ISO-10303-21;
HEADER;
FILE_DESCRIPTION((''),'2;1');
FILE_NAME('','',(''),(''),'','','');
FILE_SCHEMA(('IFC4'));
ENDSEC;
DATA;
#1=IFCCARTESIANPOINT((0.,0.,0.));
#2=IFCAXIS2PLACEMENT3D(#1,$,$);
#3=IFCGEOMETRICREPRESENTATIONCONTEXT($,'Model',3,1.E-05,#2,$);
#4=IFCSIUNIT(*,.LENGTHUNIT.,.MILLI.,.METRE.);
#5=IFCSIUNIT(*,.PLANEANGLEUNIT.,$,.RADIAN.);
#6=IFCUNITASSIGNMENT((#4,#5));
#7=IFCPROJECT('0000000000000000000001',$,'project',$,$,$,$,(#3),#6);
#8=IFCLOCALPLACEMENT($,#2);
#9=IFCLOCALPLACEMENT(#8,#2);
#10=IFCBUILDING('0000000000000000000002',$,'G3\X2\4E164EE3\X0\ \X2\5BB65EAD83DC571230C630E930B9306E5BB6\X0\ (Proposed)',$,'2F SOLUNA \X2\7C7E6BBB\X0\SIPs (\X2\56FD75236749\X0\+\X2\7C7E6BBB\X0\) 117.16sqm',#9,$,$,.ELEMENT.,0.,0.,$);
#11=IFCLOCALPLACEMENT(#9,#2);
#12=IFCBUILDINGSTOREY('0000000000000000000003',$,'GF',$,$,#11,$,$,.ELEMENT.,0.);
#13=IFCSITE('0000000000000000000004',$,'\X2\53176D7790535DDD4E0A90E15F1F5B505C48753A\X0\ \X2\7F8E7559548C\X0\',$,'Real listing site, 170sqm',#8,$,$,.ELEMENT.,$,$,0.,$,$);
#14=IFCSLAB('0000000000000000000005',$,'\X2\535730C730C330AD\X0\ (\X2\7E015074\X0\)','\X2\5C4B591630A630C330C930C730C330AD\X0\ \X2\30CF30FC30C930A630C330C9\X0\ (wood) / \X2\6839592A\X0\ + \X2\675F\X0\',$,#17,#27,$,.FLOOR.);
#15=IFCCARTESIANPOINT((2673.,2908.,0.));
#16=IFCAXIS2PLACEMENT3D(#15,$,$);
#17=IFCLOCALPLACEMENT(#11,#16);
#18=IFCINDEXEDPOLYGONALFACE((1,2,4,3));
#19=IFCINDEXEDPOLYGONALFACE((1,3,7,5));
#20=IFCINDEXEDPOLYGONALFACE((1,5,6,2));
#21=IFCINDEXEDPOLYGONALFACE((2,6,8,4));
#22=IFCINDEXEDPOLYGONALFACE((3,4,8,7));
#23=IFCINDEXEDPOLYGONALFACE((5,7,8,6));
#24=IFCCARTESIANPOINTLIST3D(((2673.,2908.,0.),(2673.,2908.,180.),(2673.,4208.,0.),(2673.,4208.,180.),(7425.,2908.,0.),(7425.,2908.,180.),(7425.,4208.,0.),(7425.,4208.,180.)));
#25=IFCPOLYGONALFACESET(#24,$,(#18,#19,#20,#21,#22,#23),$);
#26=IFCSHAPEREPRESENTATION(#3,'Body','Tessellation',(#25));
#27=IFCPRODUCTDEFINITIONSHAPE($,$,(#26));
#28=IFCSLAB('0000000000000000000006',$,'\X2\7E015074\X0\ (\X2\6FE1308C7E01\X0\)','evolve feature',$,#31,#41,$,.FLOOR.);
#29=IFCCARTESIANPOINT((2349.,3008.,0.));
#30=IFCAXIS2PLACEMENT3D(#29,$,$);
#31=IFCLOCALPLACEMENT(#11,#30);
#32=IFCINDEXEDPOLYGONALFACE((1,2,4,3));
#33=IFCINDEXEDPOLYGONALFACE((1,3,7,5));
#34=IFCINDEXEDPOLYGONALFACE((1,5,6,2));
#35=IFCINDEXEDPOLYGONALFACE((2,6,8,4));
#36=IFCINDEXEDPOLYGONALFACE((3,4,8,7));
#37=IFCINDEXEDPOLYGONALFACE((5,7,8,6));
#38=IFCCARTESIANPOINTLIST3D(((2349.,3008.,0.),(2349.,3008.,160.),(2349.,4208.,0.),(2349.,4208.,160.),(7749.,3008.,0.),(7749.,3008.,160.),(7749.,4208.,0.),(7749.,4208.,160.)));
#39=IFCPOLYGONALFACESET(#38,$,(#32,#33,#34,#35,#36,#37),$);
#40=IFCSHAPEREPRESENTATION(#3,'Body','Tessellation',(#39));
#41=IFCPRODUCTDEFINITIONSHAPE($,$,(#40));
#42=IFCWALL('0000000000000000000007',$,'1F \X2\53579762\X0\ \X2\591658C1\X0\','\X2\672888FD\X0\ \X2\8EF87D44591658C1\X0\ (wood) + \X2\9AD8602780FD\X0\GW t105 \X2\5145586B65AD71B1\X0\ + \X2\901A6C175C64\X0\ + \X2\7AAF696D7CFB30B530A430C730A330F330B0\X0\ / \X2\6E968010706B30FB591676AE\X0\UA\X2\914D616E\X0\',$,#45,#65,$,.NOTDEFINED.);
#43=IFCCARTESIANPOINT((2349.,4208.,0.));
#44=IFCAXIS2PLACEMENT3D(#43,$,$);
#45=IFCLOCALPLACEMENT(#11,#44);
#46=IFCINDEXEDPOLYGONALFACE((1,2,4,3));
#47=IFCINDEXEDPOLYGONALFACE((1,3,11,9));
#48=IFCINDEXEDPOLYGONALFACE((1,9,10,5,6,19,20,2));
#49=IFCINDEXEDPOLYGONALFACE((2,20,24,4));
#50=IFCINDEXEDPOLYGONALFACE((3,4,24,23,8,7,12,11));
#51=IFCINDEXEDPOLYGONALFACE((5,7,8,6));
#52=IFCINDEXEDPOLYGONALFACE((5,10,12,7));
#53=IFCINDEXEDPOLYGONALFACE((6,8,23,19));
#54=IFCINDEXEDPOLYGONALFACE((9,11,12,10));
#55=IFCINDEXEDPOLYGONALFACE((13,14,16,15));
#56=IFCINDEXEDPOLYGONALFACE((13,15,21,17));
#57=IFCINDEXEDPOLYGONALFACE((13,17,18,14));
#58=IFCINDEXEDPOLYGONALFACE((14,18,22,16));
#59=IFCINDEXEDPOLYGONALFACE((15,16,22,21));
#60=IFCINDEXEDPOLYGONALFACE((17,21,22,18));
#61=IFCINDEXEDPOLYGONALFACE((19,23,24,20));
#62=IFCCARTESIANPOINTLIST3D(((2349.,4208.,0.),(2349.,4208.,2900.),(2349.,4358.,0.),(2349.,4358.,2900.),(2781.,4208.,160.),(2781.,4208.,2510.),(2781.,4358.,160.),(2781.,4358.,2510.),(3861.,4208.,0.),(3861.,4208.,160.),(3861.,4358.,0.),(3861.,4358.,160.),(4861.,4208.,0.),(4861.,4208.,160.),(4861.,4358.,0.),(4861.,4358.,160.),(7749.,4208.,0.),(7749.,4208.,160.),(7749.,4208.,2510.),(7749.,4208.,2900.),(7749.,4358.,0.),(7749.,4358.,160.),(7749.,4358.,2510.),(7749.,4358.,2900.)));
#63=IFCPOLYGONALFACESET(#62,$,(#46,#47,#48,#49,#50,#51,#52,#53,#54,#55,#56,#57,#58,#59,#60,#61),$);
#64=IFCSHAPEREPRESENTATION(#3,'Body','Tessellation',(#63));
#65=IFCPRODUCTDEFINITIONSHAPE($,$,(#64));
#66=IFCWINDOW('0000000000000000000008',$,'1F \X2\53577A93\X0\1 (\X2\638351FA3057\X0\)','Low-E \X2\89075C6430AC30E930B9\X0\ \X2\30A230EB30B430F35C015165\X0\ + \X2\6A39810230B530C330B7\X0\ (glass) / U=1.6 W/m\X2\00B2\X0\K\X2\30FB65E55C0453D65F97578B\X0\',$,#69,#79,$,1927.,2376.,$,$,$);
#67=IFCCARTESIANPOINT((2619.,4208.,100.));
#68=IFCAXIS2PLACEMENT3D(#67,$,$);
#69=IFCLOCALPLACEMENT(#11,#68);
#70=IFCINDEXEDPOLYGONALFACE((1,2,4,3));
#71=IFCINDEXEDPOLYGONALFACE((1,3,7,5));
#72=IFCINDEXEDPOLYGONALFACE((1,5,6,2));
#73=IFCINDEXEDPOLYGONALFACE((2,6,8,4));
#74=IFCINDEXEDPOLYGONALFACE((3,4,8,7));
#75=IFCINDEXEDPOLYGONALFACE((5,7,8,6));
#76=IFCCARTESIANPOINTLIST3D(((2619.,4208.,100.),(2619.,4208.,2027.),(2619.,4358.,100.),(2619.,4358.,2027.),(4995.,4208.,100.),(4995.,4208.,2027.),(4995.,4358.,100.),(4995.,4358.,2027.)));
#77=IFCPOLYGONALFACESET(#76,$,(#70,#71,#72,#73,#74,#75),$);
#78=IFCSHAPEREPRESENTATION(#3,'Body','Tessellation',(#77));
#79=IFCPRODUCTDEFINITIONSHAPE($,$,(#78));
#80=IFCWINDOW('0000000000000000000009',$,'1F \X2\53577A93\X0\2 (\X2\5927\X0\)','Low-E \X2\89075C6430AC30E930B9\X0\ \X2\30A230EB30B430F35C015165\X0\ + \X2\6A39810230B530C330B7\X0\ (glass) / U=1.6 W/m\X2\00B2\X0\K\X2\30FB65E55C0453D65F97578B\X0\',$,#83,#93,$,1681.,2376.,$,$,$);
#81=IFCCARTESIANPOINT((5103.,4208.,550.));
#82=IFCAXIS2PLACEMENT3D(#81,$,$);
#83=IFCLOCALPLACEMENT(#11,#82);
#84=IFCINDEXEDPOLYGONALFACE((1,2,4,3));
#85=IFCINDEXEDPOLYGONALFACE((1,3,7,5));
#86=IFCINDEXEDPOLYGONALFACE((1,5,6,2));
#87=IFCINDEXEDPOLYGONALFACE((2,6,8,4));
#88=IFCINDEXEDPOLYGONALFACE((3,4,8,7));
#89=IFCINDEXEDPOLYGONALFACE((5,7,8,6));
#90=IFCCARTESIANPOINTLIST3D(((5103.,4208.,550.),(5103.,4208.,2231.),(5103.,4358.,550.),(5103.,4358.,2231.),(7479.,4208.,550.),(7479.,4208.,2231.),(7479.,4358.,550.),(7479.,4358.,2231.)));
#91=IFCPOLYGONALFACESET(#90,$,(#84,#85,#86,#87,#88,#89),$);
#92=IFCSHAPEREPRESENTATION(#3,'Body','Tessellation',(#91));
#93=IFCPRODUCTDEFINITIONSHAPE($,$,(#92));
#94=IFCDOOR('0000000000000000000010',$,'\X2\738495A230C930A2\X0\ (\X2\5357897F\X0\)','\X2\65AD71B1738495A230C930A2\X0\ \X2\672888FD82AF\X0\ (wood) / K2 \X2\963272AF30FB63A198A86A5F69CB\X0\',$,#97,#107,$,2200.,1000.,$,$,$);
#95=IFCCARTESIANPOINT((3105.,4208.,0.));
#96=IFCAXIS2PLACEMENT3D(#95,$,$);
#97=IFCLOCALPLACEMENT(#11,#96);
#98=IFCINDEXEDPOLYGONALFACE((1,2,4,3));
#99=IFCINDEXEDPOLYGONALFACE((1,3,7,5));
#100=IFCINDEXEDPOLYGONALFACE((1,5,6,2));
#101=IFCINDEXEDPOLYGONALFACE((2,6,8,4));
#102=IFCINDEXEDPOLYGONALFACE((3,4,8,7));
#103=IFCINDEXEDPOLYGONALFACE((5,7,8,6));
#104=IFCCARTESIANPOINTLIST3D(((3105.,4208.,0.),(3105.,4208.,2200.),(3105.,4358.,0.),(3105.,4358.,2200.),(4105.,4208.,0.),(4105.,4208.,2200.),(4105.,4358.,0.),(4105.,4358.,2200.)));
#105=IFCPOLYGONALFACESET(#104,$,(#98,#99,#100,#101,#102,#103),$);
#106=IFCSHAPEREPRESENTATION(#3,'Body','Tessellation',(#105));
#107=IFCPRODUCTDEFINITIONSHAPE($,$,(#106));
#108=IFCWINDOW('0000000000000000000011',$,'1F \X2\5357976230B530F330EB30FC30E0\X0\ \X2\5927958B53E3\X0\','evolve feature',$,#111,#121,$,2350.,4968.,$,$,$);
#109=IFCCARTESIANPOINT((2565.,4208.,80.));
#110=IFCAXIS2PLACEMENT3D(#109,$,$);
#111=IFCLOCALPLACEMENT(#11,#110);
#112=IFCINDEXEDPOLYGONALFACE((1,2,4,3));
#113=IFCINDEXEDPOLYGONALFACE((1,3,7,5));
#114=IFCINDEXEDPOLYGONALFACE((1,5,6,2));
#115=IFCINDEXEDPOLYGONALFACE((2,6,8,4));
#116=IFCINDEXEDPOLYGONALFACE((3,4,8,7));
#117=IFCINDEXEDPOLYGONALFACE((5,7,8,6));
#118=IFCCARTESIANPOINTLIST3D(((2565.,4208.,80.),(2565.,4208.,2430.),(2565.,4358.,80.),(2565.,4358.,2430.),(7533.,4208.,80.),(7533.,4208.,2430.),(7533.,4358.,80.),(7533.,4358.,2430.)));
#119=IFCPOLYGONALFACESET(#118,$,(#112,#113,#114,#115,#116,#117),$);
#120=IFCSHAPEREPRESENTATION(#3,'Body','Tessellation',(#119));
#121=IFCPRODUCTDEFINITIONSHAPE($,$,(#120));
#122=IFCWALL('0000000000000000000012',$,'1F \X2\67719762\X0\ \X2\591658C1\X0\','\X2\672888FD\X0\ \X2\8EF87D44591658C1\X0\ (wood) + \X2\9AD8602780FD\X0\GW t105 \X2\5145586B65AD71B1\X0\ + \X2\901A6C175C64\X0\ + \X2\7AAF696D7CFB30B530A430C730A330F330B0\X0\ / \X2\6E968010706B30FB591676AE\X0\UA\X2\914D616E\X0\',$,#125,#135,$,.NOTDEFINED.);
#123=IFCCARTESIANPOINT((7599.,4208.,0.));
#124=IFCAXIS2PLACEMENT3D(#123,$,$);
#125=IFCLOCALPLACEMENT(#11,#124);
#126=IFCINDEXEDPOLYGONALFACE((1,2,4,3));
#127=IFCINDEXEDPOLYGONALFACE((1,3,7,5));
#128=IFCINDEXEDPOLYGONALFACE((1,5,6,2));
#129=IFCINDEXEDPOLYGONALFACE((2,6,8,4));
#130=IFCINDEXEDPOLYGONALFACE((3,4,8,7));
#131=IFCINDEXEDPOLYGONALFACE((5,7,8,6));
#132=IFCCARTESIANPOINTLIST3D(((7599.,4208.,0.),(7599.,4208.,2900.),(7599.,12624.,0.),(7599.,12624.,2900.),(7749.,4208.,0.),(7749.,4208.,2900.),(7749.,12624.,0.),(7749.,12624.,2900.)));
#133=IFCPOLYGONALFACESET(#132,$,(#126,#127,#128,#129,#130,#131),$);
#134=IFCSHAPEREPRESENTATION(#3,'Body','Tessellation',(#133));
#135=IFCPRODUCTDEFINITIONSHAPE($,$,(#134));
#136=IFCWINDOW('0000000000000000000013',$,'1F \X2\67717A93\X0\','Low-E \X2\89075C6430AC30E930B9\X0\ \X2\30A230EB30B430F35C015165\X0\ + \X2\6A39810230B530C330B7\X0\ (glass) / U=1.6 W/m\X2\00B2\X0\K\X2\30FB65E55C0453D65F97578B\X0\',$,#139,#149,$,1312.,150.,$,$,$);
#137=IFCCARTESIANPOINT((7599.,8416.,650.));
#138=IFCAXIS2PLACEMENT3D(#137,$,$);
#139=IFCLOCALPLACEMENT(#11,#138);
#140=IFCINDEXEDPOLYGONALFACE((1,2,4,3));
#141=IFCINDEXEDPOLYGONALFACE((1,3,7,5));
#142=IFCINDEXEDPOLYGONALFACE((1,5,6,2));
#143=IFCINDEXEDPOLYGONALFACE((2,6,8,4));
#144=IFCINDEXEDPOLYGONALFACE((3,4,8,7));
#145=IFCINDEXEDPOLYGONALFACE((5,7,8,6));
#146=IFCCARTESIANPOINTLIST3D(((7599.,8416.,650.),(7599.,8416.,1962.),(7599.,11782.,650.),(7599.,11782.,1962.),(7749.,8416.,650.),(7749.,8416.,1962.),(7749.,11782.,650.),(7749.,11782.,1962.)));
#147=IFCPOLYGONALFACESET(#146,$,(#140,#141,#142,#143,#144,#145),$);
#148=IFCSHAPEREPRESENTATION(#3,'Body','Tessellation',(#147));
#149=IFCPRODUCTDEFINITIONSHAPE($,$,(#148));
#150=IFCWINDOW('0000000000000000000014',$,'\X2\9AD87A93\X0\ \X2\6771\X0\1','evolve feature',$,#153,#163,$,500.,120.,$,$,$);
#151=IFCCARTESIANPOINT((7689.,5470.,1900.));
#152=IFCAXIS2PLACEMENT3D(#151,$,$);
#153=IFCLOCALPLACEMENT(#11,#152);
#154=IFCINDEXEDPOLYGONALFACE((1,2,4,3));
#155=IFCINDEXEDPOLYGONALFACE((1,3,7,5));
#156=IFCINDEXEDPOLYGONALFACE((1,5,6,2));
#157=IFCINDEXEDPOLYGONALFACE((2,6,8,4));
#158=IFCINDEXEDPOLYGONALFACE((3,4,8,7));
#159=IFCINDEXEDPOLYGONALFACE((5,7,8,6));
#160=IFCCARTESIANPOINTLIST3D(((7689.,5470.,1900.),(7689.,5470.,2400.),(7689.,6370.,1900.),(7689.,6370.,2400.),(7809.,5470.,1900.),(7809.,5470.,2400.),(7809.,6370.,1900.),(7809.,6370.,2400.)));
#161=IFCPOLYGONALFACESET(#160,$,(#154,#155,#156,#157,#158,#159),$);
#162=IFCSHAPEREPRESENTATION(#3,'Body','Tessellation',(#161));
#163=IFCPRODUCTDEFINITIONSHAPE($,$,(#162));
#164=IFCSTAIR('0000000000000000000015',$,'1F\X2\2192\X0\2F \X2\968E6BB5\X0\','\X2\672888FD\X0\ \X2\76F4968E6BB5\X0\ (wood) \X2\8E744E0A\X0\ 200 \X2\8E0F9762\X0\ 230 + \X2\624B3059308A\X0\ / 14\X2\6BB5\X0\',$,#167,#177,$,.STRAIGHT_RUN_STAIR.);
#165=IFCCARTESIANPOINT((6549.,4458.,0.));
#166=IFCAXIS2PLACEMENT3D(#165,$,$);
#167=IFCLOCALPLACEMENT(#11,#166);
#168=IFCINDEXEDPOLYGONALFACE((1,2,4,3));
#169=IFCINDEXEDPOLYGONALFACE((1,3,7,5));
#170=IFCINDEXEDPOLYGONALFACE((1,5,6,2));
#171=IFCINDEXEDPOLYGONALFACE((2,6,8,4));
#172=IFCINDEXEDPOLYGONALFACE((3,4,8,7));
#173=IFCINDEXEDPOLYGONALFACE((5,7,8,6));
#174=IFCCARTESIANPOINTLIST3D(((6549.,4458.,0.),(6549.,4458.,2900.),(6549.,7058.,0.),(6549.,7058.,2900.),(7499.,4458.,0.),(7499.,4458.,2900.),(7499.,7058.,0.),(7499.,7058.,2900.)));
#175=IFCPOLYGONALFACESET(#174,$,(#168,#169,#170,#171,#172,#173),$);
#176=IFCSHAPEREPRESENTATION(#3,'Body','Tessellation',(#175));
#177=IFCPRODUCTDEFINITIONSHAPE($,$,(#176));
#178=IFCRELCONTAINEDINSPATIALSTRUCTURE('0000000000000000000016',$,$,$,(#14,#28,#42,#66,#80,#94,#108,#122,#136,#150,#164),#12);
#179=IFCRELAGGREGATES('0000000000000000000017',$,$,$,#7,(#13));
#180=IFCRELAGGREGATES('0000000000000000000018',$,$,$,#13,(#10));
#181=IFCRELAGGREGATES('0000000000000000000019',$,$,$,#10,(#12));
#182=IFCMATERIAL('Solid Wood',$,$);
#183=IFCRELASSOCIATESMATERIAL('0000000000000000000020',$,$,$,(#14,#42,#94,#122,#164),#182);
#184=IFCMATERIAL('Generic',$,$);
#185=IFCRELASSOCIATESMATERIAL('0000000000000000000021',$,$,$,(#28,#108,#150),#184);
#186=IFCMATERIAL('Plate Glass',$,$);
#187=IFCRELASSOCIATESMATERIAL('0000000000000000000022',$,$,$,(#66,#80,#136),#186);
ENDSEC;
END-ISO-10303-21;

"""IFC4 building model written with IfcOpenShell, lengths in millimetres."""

from ifc_helpers import new_model, si_unit, frame, frame_2d, origin, place, context, project, spatial, rectangle, extrude, material, element, fill, save


model = new_model("IFC4")

# Units and contexts
model_context = context("Model", 3, precision=1e-05, world=origin())
ifc_project = project(units=[si_unit("LENGTHUNIT", "METRE", prefix="MILLI"), si_unit("PLANEANGLEUNIT", "RADIAN")], contexts=[model_context])

# Site, building, storey
site_placement = place(None, origin())
site = spatial("IfcSite", under=ifc_project, at=site_placement, Name="北海道川上郡弟子屈町 美留和", ObjectType="Real listing site, 170sqm", CompositionType="ELEMENT", RefElevation=0.0)
building_placement = place(site_placement, origin())
building = spatial("IfcBuilding", under=site, at=building_placement, Name="G3世代 家庭菜園テラスの家 (Proposed)", ObjectType="2F SOLUNA 籾殻SIPs (国産杉+籾殻) 117.16sqm", CompositionType="ELEMENT", ElevationOfRefHeight=0.0, ElevationOfTerrain=0.0)
storey_placement = place(building_placement, origin())
storey = spatial("IfcBuildingStorey", under=building, at=storey_placement, Name="GF", CompositionType="ELEMENT", Elevation=0.0)

# Slabs
ifc_material_1 = material(Name="Solid Wood")
slab_1_placement = place(storey_placement, frame((2673.0, 2908.0, 0.0)))
element("IfcSlab", 1, at=slab_1_placement, inside=storey, material=ifc_material_1, Name="南デッキ (縁側)", Description="屋外ウッドデッキ ハードウッド (wood) / 根太 + 束", PredefinedType="FLOOR", context=model_context, shape_type="SweptSolid", body=[
    extrude(rectangle(XDim=4752.0, YDim=1300.0, at=frame_2d((2376.0, 650.0))), frame((2673.0, 2908.0, 0.0)), (0.0, 0.0, 1.0), 180.0),
])
ifc_material_2 = material(Name="Generic")
slab_2_placement = place(storey_placement, frame((2349.0, 3008.0, 0.0)))
element("IfcSlab", 2, at=slab_2_placement, inside=storey, material=ifc_material_2, Name="縁側 (濡れ縁)", Description="evolve feature", PredefinedType="FLOOR", context=model_context, shape_type="SweptSolid", body=[
    extrude(rectangle(XDim=5400.0, YDim=1200.0, at=frame_2d((2700.0, 600.0))), frame((2349.0, 3008.0, 0.0)), (0.0, 0.0, 1.0), 160.0),
])

# Wall, openings, windows, door
wall_1_placement = place(storey_placement, frame((2349.0, 4208.0, 0.0)))
wall_1 = element("IfcWall", 3, at=wall_1_placement, inside=storey, material=ifc_material_1, Name="1F 南面 外壁", Description="木製 軸組外壁 (wood) + 高性能GW t105 充填断熱 + 通気層 + 窯業系サイディング / 準耐火・外皮UA配慮", PredefinedType="NOTDEFINED", context=model_context, shape_type="SweptSolid", body=[
    extrude(rectangle(XDim=5400.0, YDim=150.0, at=frame_2d((2700.0, 75.0))), frame((2349.0, 4208.0, 0.0)), (0.0, 0.0, 1.0), 2900.0),
])
opening_1_placement = place(storey_placement, frame((2619.0, 4208.0, 100.0)))
opening_1 = element("IfcOpeningElement", 4, at=opening_1_placement, cuts=wall_1, PredefinedType="NOTDEFINED", context=model_context, shape_type="SweptSolid", body=[
    extrude(rectangle(XDim=2376.0, YDim=150.0, at=frame_2d((1188.0, 75.0))), frame((2619.0, 4208.0, 100.0)), (0.0, 0.0, 1.0), 1927.0),
])
opening_2_placement = place(storey_placement, frame((5103.0, 4208.0, 550.0)))
opening_2 = element("IfcOpeningElement", 5, at=opening_2_placement, cuts=wall_1, PredefinedType="NOTDEFINED", context=model_context, shape_type="SweptSolid", body=[
    extrude(rectangle(XDim=2376.0, YDim=150.0, at=frame_2d((1188.0, 75.0))), frame((5103.0, 4208.0, 550.0)), (0.0, 0.0, 1.0), 1681.0),
])
opening_3_placement = place(storey_placement, frame((3105.0, 4208.0, 0.0)))
opening_3 = element("IfcOpeningElement", 6, at=opening_3_placement, cuts=wall_1, PredefinedType="NOTDEFINED", context=model_context, shape_type="SweptSolid", body=[
    extrude(rectangle(XDim=1000.0, YDim=150.0, at=frame_2d((500.0, 75.0))), frame((3105.0, 4208.0, 0.0)), (0.0, 0.0, 1.0), 2200.0),
])
opening_4_placement = place(storey_placement, frame((2565.0, 4208.0, 80.0)))
opening_4 = element("IfcOpeningElement", 7, at=opening_4_placement, cuts=wall_1, PredefinedType="NOTDEFINED", context=model_context, shape_type="SweptSolid", body=[
    extrude(rectangle(XDim=4968.0, YDim=150.0, at=frame_2d((2484.0, 75.0))), frame((2565.0, 4208.0, 80.0)), (0.0, 0.0, 1.0), 2350.0),
])
ifc_material_3 = material(Name="Plate Glass")
window_1_placement = place(storey_placement, frame((2619.0, 4208.0, 100.0)))
window_1 = element("IfcWindow", 8, at=window_1_placement, inside=storey, material=ifc_material_3, Name="1F 南窓1 (掃出し)", Description="Low-E 複層ガラス アルゴン封入 + 樹脂サッシ (glass) / U=1.6 W/m²K・日射取得型", OverallHeight=1927.0, OverallWidth=2376.0, context=model_context, shape_type="SweptSolid", body=[
    extrude(rectangle(XDim=2376.0, YDim=150.0, at=frame_2d((1188.0, 75.0))), frame((2619.0, 4208.0, 100.0)), (0.0, 0.0, 1.0), 1927.0),
])
fill(opening_1, window_1)
window_2_placement = place(storey_placement, frame((5103.0, 4208.0, 550.0)))
window_2 = element("IfcWindow", 9, at=window_2_placement, inside=storey, material=ifc_material_3, Name="1F 南窓2 (大)", Description="Low-E 複層ガラス アルゴン封入 + 樹脂サッシ (glass) / U=1.6 W/m²K・日射取得型", OverallHeight=1681.0, OverallWidth=2376.0, context=model_context, shape_type="SweptSolid", body=[
    extrude(rectangle(XDim=2376.0, YDim=150.0, at=frame_2d((1188.0, 75.0))), frame((5103.0, 4208.0, 550.0)), (0.0, 0.0, 1.0), 1681.0),
])
fill(opening_2, window_2)
door_placement = place(storey_placement, frame((3105.0, 4208.0, 0.0)))
door = element("IfcDoor", 10, at=door_placement, inside=storey, material=ifc_material_1, Name="玄関ドア (南西)", Description="断熱玄関ドア 木製芯 (wood) / K2 防犯・採風機構", OverallHeight=2200.0, OverallWidth=1000.0, context=model_context, shape_type="SweptSolid", body=[
    extrude(rectangle(XDim=1000.0, YDim=150.0, at=frame_2d((500.0, 75.0))), frame((3105.0, 4208.0, 0.0)), (0.0, 0.0, 1.0), 2200.0),
])
fill(opening_3, door)
window_3_placement = place(storey_placement, frame((2565.0, 4208.0, 80.0)))
window_3 = element("IfcWindow", 11, at=window_3_placement, inside=storey, material=ifc_material_2, Name="1F 南面サンルーム 大開口", Description="evolve feature", OverallHeight=2350.0, OverallWidth=4968.0, context=model_context, shape_type="SweptSolid", body=[
    extrude(rectangle(XDim=4968.0, YDim=150.0, at=frame_2d((2484.0, 75.0))), frame((2565.0, 4208.0, 80.0)), (0.0, 0.0, 1.0), 2350.0),
])
fill(opening_4, window_3)

# Wall, openings, windows
wall_2_placement = place(storey_placement, frame((7599.0, 4208.0, 0.0)))
wall_2 = element("IfcWall", 12, at=wall_2_placement, inside=storey, material=ifc_material_1, Name="1F 東面 外壁", Description="木製 軸組外壁 (wood) + 高性能GW t105 充填断熱 + 通気層 + 窯業系サイディング / 準耐火・外皮UA配慮", PredefinedType="NOTDEFINED", context=model_context, shape_type="SweptSolid", body=[
    extrude(rectangle(XDim=150.0, YDim=8416.0, at=frame_2d((75.0, 4208.0))), frame((7599.0, 4208.0, 0.0)), (0.0, 0.0, 1.0), 2900.0),
])
opening_5_placement = place(storey_placement, frame((7599.0, 8416.0, 650.0)))
opening_5 = element("IfcOpeningElement", 13, at=opening_5_placement, cuts=wall_2, PredefinedType="NOTDEFINED", context=model_context, shape_type="SweptSolid", body=[
    extrude(rectangle(XDim=150.0, YDim=3366.0, at=frame_2d((75.0, 1683.0))), frame((7599.0, 8416.0, 650.0)), (0.0, 0.0, 1.0), 1312.0),
])
opening_6_placement = place(storey_placement, frame((7689.0, 5470.0, 1900.0)))
opening_6 = element("IfcOpeningElement", 14, at=opening_6_placement, cuts=wall_2, PredefinedType="NOTDEFINED", context=model_context, shape_type="SweptSolid", body=[
    extrude(rectangle(XDim=120.0, YDim=900.0, at=frame_2d((60.0, 450.0))), frame((7689.0, 5470.0, 1900.0)), (0.0, 0.0, 1.0), 500.0),
])
window_4_placement = place(storey_placement, frame((7599.0, 8416.0, 650.0)))
window_4 = element("IfcWindow", 15, at=window_4_placement, inside=storey, material=ifc_material_3, Name="1F 東窓", Description="Low-E 複層ガラス アルゴン封入 + 樹脂サッシ (glass) / U=1.6 W/m²K・日射取得型", OverallHeight=1312.0, OverallWidth=150.0, context=model_context, shape_type="SweptSolid", body=[
    extrude(rectangle(XDim=150.0, YDim=3366.0, at=frame_2d((75.0, 1683.0))), frame((7599.0, 8416.0, 650.0)), (0.0, 0.0, 1.0), 1312.0),
])
fill(opening_5, window_4)
window_5_placement = place(storey_placement, frame((7689.0, 5470.0, 1900.0)))
window_5 = element("IfcWindow", 16, at=window_5_placement, inside=storey, material=ifc_material_2, Name="高窓 東1", Description="evolve feature", OverallHeight=500.0, OverallWidth=120.0, context=model_context, shape_type="SweptSolid", body=[
    extrude(rectangle(XDim=120.0, YDim=900.0, at=frame_2d((60.0, 450.0))), frame((7689.0, 5470.0, 1900.0)), (0.0, 0.0, 1.0), 500.0),
])
fill(opening_6, window_5)

# Stair
stair_placement = place(storey_placement, frame((6549.0, 4458.0, 0.0)))
element("IfcStair", 17, at=stair_placement, inside=storey, material=ifc_material_1, Name="1F→2F 階段", Description="木製 直階段 (wood) 蹴上 200 踏面 230 + 手すり / 14段", PredefinedType="STRAIGHT_RUN_STAIR", context=model_context, shape_type="SweptSolid", body=[
    extrude(rectangle(XDim=950.0, YDim=2600.0, at=frame_2d((475.0, 1300.0))), frame((6549.0, 4458.0, 0.0)), (0.0, 0.0, 1.0), 2900.0),
])

save(model, "model.ifc")
